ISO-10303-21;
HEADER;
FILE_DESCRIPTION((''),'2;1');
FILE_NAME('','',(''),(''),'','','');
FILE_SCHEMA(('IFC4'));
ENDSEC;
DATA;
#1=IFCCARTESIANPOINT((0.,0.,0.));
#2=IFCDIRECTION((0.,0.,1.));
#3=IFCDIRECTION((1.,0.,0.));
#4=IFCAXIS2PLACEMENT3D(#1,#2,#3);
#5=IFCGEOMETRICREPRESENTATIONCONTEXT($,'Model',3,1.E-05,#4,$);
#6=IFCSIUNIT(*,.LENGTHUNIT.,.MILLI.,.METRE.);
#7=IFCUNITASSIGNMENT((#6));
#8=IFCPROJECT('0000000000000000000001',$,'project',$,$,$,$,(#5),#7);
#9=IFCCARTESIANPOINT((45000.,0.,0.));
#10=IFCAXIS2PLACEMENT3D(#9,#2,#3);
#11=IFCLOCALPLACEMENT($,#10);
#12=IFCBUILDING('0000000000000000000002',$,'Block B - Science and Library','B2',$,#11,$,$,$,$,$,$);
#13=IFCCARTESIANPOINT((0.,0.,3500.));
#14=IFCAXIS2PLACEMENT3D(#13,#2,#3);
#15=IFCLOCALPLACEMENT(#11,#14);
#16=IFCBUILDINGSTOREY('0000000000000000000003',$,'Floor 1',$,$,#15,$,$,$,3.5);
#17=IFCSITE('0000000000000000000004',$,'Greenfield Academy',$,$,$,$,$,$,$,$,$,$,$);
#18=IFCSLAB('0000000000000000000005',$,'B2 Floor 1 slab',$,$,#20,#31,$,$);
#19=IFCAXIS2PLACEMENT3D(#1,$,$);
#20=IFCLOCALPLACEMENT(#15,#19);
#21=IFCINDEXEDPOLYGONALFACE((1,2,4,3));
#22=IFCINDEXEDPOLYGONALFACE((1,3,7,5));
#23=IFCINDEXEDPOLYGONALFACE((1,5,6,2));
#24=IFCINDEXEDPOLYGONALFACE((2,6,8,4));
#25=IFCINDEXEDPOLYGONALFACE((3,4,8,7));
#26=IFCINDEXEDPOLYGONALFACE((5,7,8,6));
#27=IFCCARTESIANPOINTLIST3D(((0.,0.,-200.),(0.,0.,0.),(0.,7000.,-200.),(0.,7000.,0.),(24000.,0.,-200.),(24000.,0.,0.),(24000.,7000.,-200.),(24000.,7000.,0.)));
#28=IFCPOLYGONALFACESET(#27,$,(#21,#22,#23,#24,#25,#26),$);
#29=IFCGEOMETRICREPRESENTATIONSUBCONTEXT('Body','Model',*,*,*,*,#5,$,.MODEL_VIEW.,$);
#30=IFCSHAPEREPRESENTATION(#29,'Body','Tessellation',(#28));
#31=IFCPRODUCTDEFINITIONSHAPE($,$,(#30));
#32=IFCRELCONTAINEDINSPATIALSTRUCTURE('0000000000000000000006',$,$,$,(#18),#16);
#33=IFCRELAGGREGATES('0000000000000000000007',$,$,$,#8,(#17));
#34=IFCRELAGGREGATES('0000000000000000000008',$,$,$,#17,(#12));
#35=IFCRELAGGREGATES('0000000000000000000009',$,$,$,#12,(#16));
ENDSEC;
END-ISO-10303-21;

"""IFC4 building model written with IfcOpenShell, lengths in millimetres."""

from ifc_helpers import new_model, si_unit, frame, origin_with_axes, place, context, subcontext, project, spatial, indexed_curve, outline, extrude, element, save


model = new_model("IFC4")

# Units and contexts
model_context = context("Model", 3, precision=1e-05, world=origin_with_axes())
body_context = subcontext(model_context, "Body", "Model", "MODEL_VIEW")
ifc_project = project(units=[si_unit("LENGTHUNIT", "METRE", prefix="MILLI")], contexts=[model_context])

# Site, building, storey
site = spatial("IfcSite", under=ifc_project, Name="Greenfield Academy")
building_placement = place(None, frame((45000.0, 0.0, 0.0), z_axis=(0.0, 0.0, 1.0), x_axis=(1.0, 0.0, 0.0)))
building = spatial("IfcBuilding", under=site, at=building_placement, Name="Block B - Science and Library", Description="B2")
storey_placement = place(building_placement, frame((0.0, 0.0, 3500.0), z_axis=(0.0, 0.0, 1.0), x_axis=(1.0, 0.0, 0.0)))
storey = spatial("IfcBuildingStorey", under=building, at=storey_placement, Name="Floor 1", Elevation=3.5)

# Slab
slab_placement = place(storey_placement, frame((0.0, 0.0, -200.0), z_axis=(0.0, 0.0, 1.0), x_axis=(1.0, 0.0, 0.0)))
element("IfcSlab", 1, at=slab_placement, inside=storey, Name="B2 Floor 1 slab", context=body_context, shape_type="SweptSolid", body=[
    extrude(outline(indexed_curve([(0.0, 0.0), (0.0, 7000.0), (24000.0, 7000.0), (24000.0, 0.0), (0.0, 0.0)], self_intersect=False)), origin_with_axes(), (0.0, 0.0, 1.0), 200.0),
])

save(model, "model.ifc")
